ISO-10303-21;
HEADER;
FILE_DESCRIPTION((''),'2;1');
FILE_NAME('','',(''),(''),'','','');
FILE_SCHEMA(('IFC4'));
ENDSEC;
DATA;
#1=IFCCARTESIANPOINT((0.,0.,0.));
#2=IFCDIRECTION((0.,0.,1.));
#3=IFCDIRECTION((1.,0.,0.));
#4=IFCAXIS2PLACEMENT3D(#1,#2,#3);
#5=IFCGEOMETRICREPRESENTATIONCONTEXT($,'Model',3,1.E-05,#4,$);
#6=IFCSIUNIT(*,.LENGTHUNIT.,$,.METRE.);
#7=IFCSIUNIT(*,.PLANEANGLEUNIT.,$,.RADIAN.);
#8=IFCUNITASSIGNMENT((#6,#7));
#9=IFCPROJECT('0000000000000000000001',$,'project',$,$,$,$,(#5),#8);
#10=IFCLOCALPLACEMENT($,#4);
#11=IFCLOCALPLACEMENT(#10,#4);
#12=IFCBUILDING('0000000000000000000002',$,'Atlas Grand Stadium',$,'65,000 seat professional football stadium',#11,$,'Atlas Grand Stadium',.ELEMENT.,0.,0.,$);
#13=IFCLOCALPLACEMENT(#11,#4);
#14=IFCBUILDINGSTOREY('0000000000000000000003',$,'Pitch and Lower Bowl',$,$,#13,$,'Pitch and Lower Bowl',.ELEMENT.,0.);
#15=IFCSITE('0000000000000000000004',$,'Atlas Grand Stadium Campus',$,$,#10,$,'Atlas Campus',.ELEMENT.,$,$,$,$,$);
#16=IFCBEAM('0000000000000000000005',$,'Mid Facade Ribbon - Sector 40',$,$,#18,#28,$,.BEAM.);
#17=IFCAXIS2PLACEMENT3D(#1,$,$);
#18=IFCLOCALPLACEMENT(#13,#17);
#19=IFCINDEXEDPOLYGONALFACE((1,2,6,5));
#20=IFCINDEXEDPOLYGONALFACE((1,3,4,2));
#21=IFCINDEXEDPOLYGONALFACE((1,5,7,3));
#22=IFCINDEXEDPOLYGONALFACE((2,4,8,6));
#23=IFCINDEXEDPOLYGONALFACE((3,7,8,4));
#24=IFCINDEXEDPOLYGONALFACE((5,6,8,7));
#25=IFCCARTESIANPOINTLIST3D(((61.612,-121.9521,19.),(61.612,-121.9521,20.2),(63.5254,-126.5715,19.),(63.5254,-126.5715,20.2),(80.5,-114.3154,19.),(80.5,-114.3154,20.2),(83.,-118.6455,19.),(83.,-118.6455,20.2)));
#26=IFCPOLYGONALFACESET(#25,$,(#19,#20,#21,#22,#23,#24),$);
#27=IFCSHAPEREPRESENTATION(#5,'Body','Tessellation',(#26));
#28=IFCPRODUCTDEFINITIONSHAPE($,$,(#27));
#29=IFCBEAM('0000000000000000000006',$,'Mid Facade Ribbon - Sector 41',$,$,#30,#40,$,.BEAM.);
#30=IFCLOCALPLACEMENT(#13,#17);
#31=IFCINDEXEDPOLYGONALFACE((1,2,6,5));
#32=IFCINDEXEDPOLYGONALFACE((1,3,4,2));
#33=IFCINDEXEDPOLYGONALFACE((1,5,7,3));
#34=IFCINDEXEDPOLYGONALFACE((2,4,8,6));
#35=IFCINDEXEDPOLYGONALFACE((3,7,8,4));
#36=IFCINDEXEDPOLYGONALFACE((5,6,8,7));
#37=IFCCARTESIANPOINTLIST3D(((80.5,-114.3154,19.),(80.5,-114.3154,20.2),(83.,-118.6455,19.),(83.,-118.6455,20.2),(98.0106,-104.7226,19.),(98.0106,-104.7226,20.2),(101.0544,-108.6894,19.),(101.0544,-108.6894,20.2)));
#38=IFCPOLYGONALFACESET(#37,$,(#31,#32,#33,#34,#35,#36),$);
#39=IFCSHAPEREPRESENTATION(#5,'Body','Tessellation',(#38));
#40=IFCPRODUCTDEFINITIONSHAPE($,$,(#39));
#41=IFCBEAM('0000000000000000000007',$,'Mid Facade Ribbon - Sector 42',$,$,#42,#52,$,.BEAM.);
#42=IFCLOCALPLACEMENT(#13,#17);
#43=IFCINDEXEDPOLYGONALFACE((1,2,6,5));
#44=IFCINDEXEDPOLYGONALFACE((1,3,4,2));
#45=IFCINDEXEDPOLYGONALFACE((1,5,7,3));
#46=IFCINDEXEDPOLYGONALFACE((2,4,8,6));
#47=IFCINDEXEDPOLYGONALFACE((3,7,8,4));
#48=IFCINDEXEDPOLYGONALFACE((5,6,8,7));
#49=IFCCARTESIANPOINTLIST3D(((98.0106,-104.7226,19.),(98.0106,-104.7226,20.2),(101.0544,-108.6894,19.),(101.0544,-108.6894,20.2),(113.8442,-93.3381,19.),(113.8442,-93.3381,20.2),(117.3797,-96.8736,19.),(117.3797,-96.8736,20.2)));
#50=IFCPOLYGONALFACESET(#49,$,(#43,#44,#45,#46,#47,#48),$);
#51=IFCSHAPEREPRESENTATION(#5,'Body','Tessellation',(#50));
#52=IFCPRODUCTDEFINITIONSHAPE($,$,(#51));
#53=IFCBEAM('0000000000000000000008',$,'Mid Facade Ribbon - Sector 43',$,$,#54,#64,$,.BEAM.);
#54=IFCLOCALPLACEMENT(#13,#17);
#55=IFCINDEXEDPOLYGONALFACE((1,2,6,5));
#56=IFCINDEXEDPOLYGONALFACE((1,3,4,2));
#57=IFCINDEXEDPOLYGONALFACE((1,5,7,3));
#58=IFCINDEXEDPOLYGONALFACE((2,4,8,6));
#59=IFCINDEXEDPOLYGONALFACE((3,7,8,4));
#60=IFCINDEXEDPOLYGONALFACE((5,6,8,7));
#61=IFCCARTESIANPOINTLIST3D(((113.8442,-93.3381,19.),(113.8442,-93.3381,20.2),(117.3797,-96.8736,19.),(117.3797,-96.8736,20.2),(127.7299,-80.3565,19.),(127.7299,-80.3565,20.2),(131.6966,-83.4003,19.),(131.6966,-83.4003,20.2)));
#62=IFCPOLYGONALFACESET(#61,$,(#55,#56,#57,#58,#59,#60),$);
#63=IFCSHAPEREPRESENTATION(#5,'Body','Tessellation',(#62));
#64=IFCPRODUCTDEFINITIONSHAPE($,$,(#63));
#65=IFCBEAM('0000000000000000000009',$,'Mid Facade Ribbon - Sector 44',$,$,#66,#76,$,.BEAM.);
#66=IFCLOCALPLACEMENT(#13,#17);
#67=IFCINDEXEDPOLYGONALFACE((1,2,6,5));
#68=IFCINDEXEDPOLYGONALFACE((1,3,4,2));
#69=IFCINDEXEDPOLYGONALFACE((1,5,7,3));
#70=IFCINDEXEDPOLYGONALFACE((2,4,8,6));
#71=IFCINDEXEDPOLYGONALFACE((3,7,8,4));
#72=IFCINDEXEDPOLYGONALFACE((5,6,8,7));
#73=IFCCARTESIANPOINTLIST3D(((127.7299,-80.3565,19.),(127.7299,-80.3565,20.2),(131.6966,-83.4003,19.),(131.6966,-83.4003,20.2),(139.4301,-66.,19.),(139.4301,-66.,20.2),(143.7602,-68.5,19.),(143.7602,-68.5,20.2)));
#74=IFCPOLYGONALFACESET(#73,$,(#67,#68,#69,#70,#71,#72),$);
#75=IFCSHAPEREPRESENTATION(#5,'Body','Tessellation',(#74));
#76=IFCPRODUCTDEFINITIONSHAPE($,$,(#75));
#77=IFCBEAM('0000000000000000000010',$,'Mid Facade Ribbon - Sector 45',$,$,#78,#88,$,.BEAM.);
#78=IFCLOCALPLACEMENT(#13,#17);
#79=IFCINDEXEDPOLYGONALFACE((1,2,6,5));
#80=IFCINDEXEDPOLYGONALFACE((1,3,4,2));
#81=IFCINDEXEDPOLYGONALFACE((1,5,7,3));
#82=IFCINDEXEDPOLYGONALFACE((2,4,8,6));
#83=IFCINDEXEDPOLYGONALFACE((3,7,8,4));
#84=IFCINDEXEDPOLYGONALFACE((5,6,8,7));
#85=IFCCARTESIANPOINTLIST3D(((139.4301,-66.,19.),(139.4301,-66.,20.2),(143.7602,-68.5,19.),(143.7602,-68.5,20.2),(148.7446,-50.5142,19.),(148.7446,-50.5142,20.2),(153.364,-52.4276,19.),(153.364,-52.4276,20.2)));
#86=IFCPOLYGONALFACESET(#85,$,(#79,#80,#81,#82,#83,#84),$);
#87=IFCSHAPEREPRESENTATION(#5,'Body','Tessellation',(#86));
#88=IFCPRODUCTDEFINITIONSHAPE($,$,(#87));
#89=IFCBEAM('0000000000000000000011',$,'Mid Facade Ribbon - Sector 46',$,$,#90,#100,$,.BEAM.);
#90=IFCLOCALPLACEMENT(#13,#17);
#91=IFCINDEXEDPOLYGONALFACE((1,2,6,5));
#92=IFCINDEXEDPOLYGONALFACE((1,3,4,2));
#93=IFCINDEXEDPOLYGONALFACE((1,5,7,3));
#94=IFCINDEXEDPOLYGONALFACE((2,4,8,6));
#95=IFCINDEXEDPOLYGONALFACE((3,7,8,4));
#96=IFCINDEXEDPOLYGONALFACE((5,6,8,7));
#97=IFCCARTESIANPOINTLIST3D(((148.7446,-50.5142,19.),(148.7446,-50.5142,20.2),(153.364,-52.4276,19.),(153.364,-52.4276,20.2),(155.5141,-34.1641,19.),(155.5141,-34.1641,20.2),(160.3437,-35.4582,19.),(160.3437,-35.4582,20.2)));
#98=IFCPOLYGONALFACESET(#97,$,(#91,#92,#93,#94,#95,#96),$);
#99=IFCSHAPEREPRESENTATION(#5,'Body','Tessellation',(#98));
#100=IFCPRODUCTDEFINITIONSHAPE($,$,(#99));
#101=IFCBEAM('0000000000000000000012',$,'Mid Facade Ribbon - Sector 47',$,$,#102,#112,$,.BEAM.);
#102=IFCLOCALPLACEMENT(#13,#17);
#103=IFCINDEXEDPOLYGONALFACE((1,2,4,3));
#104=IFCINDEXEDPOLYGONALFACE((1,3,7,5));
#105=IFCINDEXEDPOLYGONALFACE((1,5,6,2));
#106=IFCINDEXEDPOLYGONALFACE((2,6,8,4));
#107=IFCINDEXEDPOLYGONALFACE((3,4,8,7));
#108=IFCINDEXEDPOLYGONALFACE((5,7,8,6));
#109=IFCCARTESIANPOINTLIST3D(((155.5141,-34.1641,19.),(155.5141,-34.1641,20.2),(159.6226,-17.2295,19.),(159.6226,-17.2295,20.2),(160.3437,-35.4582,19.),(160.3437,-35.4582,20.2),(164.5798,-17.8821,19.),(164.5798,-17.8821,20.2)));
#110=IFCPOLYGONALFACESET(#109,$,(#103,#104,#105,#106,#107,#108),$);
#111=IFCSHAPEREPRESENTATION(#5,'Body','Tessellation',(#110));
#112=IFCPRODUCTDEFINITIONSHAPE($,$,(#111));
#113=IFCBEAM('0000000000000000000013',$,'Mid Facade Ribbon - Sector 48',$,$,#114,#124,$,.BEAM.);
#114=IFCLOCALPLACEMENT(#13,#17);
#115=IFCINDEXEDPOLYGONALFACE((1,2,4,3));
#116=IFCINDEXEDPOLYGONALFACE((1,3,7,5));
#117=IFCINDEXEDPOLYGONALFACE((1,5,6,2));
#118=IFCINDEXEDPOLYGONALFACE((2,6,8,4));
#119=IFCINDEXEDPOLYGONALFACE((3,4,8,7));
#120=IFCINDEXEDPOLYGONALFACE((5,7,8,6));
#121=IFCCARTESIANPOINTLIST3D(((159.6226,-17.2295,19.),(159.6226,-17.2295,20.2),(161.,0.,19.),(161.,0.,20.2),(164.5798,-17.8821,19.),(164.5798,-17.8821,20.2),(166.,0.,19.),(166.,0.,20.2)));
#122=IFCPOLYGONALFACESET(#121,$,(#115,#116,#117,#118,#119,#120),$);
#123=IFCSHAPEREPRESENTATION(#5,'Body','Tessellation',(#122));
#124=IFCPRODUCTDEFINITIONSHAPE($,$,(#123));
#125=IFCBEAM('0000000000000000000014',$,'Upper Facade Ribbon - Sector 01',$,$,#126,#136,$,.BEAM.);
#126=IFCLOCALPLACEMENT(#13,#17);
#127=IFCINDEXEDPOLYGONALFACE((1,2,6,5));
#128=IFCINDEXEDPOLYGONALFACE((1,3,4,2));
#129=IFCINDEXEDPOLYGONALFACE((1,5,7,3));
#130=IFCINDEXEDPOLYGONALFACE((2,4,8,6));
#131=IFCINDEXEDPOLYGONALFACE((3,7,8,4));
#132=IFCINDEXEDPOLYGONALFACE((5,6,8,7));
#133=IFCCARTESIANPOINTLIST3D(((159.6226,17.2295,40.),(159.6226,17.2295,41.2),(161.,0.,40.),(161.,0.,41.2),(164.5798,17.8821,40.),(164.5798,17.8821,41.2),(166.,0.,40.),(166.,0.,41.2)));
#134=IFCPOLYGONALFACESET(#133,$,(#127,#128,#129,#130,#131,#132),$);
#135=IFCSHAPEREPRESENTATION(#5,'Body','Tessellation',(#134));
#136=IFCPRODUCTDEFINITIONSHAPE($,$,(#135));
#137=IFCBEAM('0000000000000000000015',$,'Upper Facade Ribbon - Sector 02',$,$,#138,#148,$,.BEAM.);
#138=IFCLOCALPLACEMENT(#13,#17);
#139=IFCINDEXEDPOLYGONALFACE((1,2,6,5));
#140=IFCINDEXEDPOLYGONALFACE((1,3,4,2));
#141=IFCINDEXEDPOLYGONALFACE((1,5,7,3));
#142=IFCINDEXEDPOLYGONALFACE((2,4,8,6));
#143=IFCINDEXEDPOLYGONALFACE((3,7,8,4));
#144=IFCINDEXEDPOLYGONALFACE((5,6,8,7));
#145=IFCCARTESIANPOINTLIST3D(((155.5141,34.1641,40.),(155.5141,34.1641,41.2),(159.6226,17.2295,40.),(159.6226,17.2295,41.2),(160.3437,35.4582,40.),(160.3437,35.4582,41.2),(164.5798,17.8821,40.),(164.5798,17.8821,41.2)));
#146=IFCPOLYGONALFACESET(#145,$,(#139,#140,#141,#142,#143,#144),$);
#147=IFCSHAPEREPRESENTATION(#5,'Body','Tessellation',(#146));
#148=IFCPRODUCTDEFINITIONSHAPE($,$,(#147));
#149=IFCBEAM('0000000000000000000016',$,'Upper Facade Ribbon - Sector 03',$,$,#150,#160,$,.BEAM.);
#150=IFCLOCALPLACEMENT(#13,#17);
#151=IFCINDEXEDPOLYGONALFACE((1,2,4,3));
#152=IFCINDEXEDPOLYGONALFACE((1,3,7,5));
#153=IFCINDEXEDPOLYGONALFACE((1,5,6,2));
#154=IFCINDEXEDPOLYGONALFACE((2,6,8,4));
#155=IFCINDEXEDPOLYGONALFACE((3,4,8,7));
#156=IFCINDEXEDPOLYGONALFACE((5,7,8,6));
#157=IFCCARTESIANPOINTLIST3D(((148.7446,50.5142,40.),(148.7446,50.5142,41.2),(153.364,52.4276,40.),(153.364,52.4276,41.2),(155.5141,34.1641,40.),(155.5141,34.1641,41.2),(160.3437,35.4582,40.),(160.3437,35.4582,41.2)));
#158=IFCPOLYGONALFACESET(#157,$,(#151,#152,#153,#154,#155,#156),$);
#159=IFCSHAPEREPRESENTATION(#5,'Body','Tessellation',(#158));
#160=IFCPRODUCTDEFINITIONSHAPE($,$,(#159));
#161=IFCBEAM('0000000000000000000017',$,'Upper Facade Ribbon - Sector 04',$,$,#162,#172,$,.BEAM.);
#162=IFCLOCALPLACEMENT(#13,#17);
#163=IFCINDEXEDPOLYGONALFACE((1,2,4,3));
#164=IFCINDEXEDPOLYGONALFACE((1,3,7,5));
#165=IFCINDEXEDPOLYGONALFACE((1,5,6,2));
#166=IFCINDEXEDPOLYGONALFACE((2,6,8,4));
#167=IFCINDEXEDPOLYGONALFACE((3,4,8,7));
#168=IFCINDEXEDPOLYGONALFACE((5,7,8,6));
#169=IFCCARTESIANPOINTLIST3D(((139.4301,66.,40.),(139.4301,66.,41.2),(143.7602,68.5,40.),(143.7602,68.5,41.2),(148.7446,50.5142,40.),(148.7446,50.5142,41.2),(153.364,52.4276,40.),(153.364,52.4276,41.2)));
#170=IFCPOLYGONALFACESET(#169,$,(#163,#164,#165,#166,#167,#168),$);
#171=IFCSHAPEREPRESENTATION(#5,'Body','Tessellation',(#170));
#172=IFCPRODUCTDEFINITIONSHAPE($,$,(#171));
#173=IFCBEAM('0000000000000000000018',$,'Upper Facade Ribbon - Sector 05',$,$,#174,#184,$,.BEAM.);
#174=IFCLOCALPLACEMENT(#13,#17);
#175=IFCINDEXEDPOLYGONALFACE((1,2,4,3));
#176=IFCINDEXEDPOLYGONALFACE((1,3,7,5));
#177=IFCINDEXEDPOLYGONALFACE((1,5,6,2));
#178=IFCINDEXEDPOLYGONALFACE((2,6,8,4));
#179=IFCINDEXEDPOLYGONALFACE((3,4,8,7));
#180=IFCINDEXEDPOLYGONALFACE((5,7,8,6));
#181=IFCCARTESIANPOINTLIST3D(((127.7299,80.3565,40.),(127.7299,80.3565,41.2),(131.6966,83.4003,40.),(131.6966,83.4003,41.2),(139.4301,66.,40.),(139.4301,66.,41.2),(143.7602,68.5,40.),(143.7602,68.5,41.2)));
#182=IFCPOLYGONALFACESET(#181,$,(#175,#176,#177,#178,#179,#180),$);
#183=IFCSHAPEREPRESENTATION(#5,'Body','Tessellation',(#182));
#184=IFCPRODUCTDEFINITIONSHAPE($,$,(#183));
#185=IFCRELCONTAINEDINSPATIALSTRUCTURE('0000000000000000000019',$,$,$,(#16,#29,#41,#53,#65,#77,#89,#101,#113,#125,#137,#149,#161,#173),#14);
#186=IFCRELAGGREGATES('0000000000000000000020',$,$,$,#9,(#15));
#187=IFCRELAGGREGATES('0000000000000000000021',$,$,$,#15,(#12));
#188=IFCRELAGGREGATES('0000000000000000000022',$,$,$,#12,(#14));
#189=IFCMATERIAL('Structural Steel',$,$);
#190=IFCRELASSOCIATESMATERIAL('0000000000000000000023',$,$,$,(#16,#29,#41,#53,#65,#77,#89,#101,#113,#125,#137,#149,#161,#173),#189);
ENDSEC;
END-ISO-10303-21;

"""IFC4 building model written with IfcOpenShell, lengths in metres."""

from ifc_helpers import new_model, si_unit, frame, origin_with_axes, place, context, project, spatial, polyline, outline, extrude, material, element, save


model = new_model("IFC4")

# Units and contexts
model_context = context("Model", 3, precision=1e-05, world=origin_with_axes())
ifc_project = project(units=[si_unit("LENGTHUNIT", "METRE"), si_unit("PLANEANGLEUNIT", "RADIAN")], contexts=[model_context])

# Site, building, storey
site_placement = place(None, origin_with_axes())
site = spatial("IfcSite", under=ifc_project, at=site_placement, Name="Atlas Grand Stadium Campus", LongName="Atlas Campus", CompositionType="ELEMENT")
building_placement = place(site_placement, origin_with_axes())
building = spatial("IfcBuilding", under=site, at=building_placement, Name="Atlas Grand Stadium", ObjectType="65,000 seat professional football stadium", LongName="Atlas Grand Stadium", CompositionType="ELEMENT", ElevationOfRefHeight=0.0, ElevationOfTerrain=0.0)
storey_placement = place(building_placement, origin_with_axes())
storey = spatial("IfcBuildingStorey", under=building, at=storey_placement, Name="Pitch and Lower Bowl", LongName="Pitch and Lower Bowl", CompositionType="ELEMENT", Elevation=0.0)

# Beams
ifc_material = material(Name="Structural Steel")
beam_1_placement = place(storey_placement, frame((0.0, 0.0, 19.0), z_axis=(0.0, 0.0, 1.0), x_axis=(1.0, 0.0, 0.0)))
element("IfcBeam", 1, at=beam_1_placement, inside=storey, material=ifc_material, Name="Mid Facade Ribbon - Sector 40", PredefinedType="BEAM", context=model_context, shape_type="SweptSolid", body=[
    extrude(outline(polyline([(63.5254, -126.5715), (83.0, -118.6455), (80.5, -114.3153), (61.612, -121.9521), (63.5254, -126.5715)])), origin_with_axes(), (0.0, 0.0, 1.0), 1.2),
])
beam_2_placement = place(storey_placement, frame((0.0, 0.0, 19.0), z_axis=(0.0, 0.0, 1.0), x_axis=(1.0, 0.0, 0.0)))
element("IfcBeam", 2, at=beam_2_placement, inside=storey, material=ifc_material, Name="Mid Facade Ribbon - Sector 41", PredefinedType="BEAM", context=model_context, shape_type="SweptSolid", body=[
    extrude(outline(polyline([(83.0, -118.6455), (101.0544, -108.6894), (98.0106, -104.7226), (80.5, -114.3153), (83.0, -118.6455)])), origin_with_axes(), (0.0, 0.0, 1.0), 1.2),
])
beam_3_placement = place(storey_placement, frame((0.0, 0.0, 19.0), z_axis=(0.0, 0.0, 1.0), x_axis=(1.0, 0.0, 0.0)))
element("IfcBeam", 3, at=beam_3_placement, inside=storey, material=ifc_material, Name="Mid Facade Ribbon - Sector 42", PredefinedType="BEAM", context=model_context, shape_type="SweptSolid", body=[
    extrude(outline(polyline([(101.0544, -108.6894), (117.3797, -96.8736), (113.8442, -93.3381), (98.0106, -104.7226), (101.0544, -108.6894)])), origin_with_axes(), (0.0, 0.0, 1.0), 1.2),
])
beam_4_placement = place(storey_placement, frame((0.0, 0.0, 19.0), z_axis=(0.0, 0.0, 1.0), x_axis=(1.0, 0.0, 0.0)))
element("IfcBeam", 4, at=beam_4_placement, inside=storey, material=ifc_material, Name="Mid Facade Ribbon - Sector 43", PredefinedType="BEAM", context=model_context, shape_type="SweptSolid", body=[
    extrude(outline(polyline([(117.3797, -96.8736), (131.6967, -83.4003), (127.7299, -80.3565), (113.8442, -93.3381), (117.3797, -96.8736)])), origin_with_axes(), (0.0, 0.0, 1.0), 1.2),
])
beam_5_placement = place(storey_placement, frame((0.0, 0.0, 19.0), z_axis=(0.0, 0.0, 1.0), x_axis=(1.0, 0.0, 0.0)))
element("IfcBeam", 5, at=beam_5_placement, inside=storey, material=ifc_material, Name="Mid Facade Ribbon - Sector 44", PredefinedType="BEAM", context=model_context, shape_type="SweptSolid", body=[
    extrude(outline(polyline([(131.6967, -83.4003), (143.7602, -68.5), (139.4301, -66.0), (127.7299, -80.3565), (131.6967, -83.4003)])), origin_with_axes(), (0.0, 0.0, 1.0), 1.2),
])
beam_6_placement = place(storey_placement, frame((0.0, 0.0, 19.0), z_axis=(0.0, 0.0, 1.0), x_axis=(1.0, 0.0, 0.0)))
element("IfcBeam", 6, at=beam_6_placement, inside=storey, material=ifc_material, Name="Mid Facade Ribbon - Sector 45", PredefinedType="BEAM", context=model_context, shape_type="SweptSolid", body=[
    extrude(outline(polyline([(143.7602, -68.5), (153.364, -52.4276), (148.7446, -50.5142), (139.4301, -66.0), (143.7602, -68.5)])), origin_with_axes(), (0.0, 0.0, 1.0), 1.2),
])
beam_7_placement = place(storey_placement, frame((0.0, 0.0, 19.0), z_axis=(0.0, 0.0, 1.0), x_axis=(1.0, 0.0, 0.0)))
element("IfcBeam", 7, at=beam_7_placement, inside=storey, material=ifc_material, Name="Mid Facade Ribbon - Sector 46", PredefinedType="BEAM", context=model_context, shape_type="SweptSolid", body=[
    extrude(outline(polyline([(153.364, -52.4276), (160.3437, -35.4582), (155.5141, -34.1641), (148.7446, -50.5142), (153.364, -52.4276)])), origin_with_axes(), (0.0, 0.0, 1.0), 1.2),
])
beam_8_placement = place(storey_placement, frame((0.0, 0.0, 19.0), z_axis=(0.0, 0.0, 1.0), x_axis=(1.0, 0.0, 0.0)))
element("IfcBeam", 8, at=beam_8_placement, inside=storey, material=ifc_material, Name="Mid Facade Ribbon - Sector 47", PredefinedType="BEAM", context=model_context, shape_type="SweptSolid", body=[
    extrude(outline(polyline([(160.3437, -35.4582), (164.5798, -17.8821), (159.6226, -17.2295), (155.5141, -34.1641), (160.3437, -35.4582)])), origin_with_axes(), (0.0, 0.0, 1.0), 1.2),
])
beam_9_placement = place(storey_placement, frame((0.0, 0.0, 19.0), z_axis=(0.0, 0.0, 1.0), x_axis=(1.0, 0.0, 0.0)))
element("IfcBeam", 9, at=beam_9_placement, inside=storey, material=ifc_material, Name="Mid Facade Ribbon - Sector 48", PredefinedType="BEAM", context=model_context, shape_type="SweptSolid", body=[
    extrude(outline(polyline([(164.5798, -17.8821), (166.0, 0.0), (161.0, 0.0), (159.6226, -17.2295), (164.5798, -17.8821)])), origin_with_axes(), (0.0, 0.0, 1.0), 1.2),
])
beam_10_placement = place(storey_placement, frame((0.0, 0.0, 40.0), z_axis=(0.0, 0.0, 1.0), x_axis=(1.0, 0.0, 0.0)))
element("IfcBeam", 10, at=beam_10_placement, inside=storey, material=ifc_material, Name="Upper Facade Ribbon - Sector 01", PredefinedType="BEAM", context=model_context, shape_type="SweptSolid", body=[
    extrude(outline(polyline([(166.0, 0.0), (164.5798, 17.8821), (159.6226, 17.2295), (161.0, 0.0), (166.0, 0.0)])), origin_with_axes(), (0.0, 0.0, 1.0), 1.2),
])
beam_11_placement = place(storey_placement, frame((0.0, 0.0, 40.0), z_axis=(0.0, 0.0, 1.0), x_axis=(1.0, 0.0, 0.0)))
element("IfcBeam", 11, at=beam_11_placement, inside=storey, material=ifc_material, Name="Upper Facade Ribbon - Sector 02", PredefinedType="BEAM", context=model_context, shape_type="SweptSolid", body=[
    extrude(outline(polyline([(164.5798, 17.8821), (160.3437, 35.4582), (155.5141, 34.1641), (159.6226, 17.2295), (164.5798, 17.8821)])), origin_with_axes(), (0.0, 0.0, 1.0), 1.2),
])
beam_12_placement = place(storey_placement, frame((0.0, 0.0, 40.0), z_axis=(0.0, 0.0, 1.0), x_axis=(1.0, 0.0, 0.0)))
element("IfcBeam", 12, at=beam_12_placement, inside=storey, material=ifc_material, Name="Upper Facade Ribbon - Sector 03", PredefinedType="BEAM", context=model_context, shape_type="SweptSolid", body=[
    extrude(outline(polyline([(160.3437, 35.4582), (153.364, 52.4276), (148.7446, 50.5142), (155.5141, 34.1641), (160.3437, 35.4582)])), origin_with_axes(), (0.0, 0.0, 1.0), 1.2),
])
beam_13_placement = place(storey_placement, frame((0.0, 0.0, 40.0), z_axis=(0.0, 0.0, 1.0), x_axis=(1.0, 0.0, 0.0)))
element("IfcBeam", 13, at=beam_13_placement, inside=storey, material=ifc_material, Name="Upper Facade Ribbon - Sector 04", PredefinedType="BEAM", context=model_context, shape_type="SweptSolid", body=[
    extrude(outline(polyline([(153.364, 52.4276), (143.7602, 68.5), (139.4301, 66.0), (148.7446, 50.5142), (153.364, 52.4276)])), origin_with_axes(), (0.0, 0.0, 1.0), 1.2),
])
beam_14_placement = place(storey_placement, frame((0.0, 0.0, 40.0), z_axis=(0.0, 0.0, 1.0), x_axis=(1.0, 0.0, 0.0)))
element("IfcBeam", 14, at=beam_14_placement, inside=storey, material=ifc_material, Name="Upper Facade Ribbon - Sector 05", PredefinedType="BEAM", context=model_context, shape_type="SweptSolid", body=[
    extrude(outline(polyline([(143.7602, 68.5), (131.6967, 83.4003), (127.7299, 80.3565), (139.4301, 66.0), (143.7602, 68.5)])), origin_with_axes(), (0.0, 0.0, 1.0), 1.2),
])

save(model, "model.ifc")
